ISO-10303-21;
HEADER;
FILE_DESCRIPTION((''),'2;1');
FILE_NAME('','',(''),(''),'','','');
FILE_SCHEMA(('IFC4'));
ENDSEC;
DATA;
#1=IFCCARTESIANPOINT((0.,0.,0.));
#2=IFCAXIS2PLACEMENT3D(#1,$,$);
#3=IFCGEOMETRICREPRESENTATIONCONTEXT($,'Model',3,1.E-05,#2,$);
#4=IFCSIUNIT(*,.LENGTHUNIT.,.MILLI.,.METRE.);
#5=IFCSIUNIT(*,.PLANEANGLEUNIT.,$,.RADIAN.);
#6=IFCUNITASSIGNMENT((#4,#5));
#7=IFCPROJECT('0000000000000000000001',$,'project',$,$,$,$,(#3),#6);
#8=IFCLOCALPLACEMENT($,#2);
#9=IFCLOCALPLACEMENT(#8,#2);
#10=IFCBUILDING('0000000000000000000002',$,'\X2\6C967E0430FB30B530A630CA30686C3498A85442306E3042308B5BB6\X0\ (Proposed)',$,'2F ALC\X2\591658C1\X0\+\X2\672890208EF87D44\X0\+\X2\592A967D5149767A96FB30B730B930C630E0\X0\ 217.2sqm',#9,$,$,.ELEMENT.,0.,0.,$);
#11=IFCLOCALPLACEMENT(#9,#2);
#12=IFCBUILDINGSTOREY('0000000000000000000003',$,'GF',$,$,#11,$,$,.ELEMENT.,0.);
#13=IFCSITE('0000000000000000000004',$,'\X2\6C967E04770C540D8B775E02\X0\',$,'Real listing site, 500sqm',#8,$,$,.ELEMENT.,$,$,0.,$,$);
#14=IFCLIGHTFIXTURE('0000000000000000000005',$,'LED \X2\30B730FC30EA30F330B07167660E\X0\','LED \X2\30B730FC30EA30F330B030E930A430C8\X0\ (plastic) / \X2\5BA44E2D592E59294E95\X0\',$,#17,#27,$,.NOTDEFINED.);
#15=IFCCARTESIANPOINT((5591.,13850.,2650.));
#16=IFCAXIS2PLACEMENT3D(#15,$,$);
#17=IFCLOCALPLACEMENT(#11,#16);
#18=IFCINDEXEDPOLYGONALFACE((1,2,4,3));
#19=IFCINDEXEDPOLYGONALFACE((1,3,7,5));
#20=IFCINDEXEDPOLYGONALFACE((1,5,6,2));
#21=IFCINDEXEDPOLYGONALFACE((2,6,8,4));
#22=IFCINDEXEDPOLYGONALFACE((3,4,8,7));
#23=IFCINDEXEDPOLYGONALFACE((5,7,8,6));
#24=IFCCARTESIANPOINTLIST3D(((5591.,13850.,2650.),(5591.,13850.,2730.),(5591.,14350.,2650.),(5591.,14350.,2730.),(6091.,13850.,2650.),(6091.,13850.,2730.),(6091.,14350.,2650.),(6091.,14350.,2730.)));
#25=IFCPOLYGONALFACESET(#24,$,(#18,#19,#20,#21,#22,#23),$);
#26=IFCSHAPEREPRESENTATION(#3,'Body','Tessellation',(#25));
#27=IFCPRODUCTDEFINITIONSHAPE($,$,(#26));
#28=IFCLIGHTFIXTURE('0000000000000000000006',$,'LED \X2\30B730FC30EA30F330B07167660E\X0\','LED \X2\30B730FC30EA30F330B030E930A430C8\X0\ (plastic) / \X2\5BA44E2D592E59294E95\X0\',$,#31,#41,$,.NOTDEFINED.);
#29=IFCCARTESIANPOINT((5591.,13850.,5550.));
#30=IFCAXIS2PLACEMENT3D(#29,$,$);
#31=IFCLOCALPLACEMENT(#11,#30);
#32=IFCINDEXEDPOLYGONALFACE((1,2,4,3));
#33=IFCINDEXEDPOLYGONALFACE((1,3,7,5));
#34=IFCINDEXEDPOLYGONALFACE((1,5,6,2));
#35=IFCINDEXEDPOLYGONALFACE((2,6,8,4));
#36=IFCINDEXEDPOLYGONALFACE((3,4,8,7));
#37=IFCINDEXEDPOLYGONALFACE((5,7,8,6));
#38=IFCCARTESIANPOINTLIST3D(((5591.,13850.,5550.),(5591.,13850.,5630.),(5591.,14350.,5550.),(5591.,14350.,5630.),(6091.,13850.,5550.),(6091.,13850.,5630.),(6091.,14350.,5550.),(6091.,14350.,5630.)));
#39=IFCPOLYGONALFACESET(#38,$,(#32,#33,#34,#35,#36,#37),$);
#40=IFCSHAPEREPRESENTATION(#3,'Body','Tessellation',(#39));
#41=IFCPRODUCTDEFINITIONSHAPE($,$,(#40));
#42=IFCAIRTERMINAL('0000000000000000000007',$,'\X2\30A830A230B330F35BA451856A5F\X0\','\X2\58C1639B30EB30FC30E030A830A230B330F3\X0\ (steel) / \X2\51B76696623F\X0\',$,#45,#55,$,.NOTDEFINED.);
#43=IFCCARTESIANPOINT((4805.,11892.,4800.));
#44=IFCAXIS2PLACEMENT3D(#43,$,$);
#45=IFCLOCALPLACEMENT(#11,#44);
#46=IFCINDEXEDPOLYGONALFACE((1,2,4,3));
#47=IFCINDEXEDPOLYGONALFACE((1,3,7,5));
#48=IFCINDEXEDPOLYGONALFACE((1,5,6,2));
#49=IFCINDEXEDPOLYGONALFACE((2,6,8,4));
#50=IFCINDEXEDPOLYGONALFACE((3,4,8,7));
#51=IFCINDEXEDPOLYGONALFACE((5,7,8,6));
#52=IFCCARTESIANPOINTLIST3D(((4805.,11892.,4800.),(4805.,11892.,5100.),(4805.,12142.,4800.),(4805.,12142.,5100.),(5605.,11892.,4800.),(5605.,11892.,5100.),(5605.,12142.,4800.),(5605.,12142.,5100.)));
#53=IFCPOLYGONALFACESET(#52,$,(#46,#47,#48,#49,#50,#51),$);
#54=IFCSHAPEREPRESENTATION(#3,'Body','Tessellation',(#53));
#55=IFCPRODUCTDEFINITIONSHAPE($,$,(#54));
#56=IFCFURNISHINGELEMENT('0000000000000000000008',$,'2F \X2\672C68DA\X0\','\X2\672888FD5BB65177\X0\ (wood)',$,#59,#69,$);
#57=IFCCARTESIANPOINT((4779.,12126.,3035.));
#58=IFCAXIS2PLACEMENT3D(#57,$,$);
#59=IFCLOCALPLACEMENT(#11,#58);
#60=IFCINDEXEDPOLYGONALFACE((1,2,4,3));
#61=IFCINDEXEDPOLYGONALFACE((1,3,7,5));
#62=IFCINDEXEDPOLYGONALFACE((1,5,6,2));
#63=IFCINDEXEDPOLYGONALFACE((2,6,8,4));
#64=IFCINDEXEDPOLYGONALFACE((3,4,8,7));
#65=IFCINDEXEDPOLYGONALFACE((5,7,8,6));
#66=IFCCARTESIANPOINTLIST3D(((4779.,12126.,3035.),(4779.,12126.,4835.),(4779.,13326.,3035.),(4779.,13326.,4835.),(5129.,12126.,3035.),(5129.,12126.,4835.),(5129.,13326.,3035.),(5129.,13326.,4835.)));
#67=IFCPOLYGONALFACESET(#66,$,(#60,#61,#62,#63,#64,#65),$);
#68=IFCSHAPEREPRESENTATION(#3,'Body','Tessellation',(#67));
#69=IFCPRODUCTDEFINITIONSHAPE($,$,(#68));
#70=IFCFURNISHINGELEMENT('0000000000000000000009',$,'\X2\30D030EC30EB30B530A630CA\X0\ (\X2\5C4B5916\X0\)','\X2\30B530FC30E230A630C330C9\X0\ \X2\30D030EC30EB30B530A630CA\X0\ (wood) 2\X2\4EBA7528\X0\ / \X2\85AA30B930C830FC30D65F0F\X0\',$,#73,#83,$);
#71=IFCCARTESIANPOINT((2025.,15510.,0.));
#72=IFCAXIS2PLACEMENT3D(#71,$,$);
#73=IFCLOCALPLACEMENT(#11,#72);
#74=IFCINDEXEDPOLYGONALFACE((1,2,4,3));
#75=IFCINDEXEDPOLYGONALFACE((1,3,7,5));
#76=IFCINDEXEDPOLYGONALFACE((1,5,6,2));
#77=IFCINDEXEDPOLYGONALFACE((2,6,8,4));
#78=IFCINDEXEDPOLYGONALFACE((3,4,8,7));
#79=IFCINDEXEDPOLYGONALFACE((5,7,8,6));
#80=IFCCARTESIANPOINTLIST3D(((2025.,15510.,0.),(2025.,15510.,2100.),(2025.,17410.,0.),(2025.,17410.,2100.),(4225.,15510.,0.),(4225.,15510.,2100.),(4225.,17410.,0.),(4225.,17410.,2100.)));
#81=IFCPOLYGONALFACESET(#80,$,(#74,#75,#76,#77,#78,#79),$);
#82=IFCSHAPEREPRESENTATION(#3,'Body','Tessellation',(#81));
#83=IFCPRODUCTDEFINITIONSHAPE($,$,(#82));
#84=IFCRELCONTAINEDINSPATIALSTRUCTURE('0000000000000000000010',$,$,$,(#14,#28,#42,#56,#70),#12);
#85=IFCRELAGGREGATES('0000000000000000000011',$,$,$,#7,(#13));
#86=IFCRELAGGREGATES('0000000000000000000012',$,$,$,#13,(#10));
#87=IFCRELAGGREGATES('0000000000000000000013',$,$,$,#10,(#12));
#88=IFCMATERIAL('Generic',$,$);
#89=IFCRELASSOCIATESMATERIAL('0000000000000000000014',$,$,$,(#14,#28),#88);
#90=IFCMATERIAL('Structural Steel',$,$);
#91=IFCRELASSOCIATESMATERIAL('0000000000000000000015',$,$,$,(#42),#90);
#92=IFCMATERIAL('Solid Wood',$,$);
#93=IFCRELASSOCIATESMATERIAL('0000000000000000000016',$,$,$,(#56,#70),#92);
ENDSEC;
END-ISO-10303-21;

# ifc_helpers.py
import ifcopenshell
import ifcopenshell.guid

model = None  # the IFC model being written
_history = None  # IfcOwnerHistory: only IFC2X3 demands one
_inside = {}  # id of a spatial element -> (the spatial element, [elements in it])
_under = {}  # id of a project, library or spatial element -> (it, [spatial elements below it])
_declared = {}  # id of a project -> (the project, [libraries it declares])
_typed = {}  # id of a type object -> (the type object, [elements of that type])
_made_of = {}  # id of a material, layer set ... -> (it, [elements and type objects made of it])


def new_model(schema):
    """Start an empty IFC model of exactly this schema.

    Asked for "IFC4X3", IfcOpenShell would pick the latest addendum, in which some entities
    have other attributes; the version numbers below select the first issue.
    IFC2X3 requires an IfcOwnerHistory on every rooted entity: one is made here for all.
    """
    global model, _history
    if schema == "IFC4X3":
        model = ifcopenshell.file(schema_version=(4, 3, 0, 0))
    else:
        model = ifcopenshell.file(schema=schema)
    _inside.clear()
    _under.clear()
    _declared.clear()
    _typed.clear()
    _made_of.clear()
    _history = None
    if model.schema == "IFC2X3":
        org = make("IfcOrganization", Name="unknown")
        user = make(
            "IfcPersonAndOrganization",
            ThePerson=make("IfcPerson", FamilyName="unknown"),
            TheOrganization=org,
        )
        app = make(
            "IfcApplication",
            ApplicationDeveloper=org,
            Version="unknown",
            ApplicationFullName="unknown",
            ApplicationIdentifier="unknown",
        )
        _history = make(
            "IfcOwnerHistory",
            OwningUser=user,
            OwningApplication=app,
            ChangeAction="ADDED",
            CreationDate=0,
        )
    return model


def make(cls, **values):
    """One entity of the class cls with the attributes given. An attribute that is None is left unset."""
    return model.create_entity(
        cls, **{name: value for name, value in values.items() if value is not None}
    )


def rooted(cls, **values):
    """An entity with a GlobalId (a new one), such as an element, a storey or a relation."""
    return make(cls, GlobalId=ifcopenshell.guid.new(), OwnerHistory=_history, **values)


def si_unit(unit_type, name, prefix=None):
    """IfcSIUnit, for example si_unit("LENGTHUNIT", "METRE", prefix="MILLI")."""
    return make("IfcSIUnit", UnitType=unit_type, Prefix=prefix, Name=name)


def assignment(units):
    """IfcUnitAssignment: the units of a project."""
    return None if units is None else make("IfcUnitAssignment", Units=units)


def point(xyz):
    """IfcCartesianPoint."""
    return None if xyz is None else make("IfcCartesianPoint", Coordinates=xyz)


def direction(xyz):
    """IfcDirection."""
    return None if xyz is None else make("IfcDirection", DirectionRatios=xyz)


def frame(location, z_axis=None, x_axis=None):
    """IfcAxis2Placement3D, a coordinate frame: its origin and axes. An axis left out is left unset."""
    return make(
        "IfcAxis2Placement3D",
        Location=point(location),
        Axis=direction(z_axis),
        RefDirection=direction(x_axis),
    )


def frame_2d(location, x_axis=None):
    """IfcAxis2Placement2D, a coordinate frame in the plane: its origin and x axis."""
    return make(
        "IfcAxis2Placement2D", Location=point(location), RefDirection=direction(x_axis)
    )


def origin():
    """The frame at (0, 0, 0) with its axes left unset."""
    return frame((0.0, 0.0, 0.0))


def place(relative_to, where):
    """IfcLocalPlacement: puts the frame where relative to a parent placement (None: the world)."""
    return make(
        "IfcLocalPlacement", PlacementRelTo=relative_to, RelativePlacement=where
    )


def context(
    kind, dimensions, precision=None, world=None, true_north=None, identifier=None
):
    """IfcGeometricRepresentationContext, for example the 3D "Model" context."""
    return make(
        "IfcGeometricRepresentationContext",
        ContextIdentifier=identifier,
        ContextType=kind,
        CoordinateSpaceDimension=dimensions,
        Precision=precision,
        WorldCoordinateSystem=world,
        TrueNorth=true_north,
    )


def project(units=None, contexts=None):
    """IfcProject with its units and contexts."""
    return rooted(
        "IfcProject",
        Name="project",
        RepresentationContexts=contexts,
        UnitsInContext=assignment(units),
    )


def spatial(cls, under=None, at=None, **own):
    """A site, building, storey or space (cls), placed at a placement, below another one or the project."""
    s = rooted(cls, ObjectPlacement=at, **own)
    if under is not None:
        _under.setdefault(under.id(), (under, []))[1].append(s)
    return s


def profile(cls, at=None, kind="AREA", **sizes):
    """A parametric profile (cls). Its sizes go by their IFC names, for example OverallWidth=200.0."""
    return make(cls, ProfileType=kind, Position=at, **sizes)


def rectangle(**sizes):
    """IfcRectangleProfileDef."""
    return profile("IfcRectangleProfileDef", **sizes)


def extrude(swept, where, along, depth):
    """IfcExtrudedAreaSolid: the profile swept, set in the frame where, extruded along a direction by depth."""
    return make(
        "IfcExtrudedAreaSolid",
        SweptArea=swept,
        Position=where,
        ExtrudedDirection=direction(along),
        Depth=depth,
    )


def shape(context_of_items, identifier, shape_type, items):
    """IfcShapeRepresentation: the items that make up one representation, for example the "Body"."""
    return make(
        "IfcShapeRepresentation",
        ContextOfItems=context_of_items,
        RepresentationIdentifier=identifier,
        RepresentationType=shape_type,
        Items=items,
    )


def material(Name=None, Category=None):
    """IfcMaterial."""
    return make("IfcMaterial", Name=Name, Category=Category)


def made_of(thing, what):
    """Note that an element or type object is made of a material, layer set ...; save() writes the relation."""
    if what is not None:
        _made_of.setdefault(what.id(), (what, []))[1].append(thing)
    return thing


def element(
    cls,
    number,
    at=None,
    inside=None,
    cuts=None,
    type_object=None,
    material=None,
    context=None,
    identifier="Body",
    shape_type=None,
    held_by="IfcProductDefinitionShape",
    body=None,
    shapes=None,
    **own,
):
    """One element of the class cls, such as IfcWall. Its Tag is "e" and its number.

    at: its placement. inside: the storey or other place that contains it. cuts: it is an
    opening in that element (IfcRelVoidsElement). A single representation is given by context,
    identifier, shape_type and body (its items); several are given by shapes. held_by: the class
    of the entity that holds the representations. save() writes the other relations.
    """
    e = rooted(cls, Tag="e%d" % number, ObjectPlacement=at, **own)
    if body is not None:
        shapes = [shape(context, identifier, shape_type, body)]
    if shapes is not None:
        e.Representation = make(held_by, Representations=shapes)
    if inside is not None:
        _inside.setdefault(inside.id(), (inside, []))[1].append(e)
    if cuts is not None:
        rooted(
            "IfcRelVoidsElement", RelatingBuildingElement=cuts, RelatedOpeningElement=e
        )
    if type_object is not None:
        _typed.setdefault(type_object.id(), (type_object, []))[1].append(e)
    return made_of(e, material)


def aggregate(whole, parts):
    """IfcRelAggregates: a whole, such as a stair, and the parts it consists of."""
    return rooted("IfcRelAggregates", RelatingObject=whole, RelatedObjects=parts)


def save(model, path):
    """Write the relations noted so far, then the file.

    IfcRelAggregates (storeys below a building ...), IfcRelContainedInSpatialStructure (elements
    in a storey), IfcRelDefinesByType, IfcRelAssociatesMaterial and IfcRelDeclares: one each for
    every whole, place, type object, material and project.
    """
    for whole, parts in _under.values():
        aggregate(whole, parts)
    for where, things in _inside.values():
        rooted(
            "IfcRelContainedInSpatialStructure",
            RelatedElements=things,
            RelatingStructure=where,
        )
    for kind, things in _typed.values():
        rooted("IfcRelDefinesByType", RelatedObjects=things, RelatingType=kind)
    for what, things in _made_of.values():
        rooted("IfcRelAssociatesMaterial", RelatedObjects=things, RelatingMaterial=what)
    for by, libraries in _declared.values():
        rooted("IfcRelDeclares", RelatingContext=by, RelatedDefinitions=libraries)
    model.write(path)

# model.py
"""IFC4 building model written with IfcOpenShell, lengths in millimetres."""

from ifc_helpers import new_model, si_unit, frame, frame_2d, origin, place, context, project, spatial, rectangle, extrude, material, element, save


model = new_model("IFC4")

# Units and contexts
model_context = context("Model", 3, precision=1e-05, world=origin())
ifc_project = project(units=[si_unit("LENGTHUNIT", "METRE", prefix="MILLI"), si_unit("PLANEANGLEUNIT", "RADIAN")], contexts=[model_context])

# Site, building, storey
site_placement = place(None, origin())
site = spatial("IfcSite", under=ifc_project, at=site_placement, Name="沖縄県名護市", ObjectType="Real listing site, 500sqm", CompositionType="ELEMENT", RefElevation=0.0)
building_placement = place(site_placement, origin())
building = spatial("IfcBuilding", under=site, at=building_placement, Name="沖縄・サウナと水風呂のある家 (Proposed)", ObjectType="2F ALC外壁+木造軸組+太陽光発電システム 217.2sqm", CompositionType="ELEMENT", ElevationOfRefHeight=0.0, ElevationOfTerrain=0.0)
storey_placement = place(building_placement, origin())
storey = spatial("IfcBuildingStorey", under=building, at=storey_placement, Name="GF", CompositionType="ELEMENT", Elevation=0.0)

# Shared definitions
ifc_material_1 = material(Name="Solid Wood")

# Shared definitions
ifc_material_2 = material(Name="Structural Steel")

# Shared definitions
ifc_material_3 = material(Name="Generic")

# Light fixtures
light_fixture_1_placement = place(storey_placement, frame((5591.0, 13850.0, 2650.0)))
element("IfcLightFixture", 1, at=light_fixture_1_placement, inside=storey, material=ifc_material_3, Name="LED シーリング照明", Description="LED シーリングライト (plastic) / 室中央天井", PredefinedType="NOTDEFINED", context=model_context, shape_type="SweptSolid", body=[
    extrude(rectangle(XDim=500.0, YDim=500.0, at=frame_2d((250.0, 250.0))), frame((5591.0, 13850.0, 2650.0)), (0.0, 0.0, 1.0), 80.0),
])
light_fixture_2_placement = place(storey_placement, frame((5591.0, 13850.0, 5550.0)))
element("IfcLightFixture", 2, at=light_fixture_2_placement, inside=storey, material=ifc_material_3, Name="LED シーリング照明", Description="LED シーリングライト (plastic) / 室中央天井", PredefinedType="NOTDEFINED", context=model_context, shape_type="SweptSolid", body=[
    extrude(rectangle(XDim=500.0, YDim=500.0, at=frame_2d((250.0, 250.0))), frame((5591.0, 13850.0, 5550.0)), (0.0, 0.0, 1.0), 80.0),
])

# Air terminal
air_terminal_placement = place(storey_placement, frame((4805.0, 11892.0, 4800.0)))
element("IfcAirTerminal", 3, at=air_terminal_placement, inside=storey, material=ifc_material_2, Name="エアコン室内機", Description="壁掛ルームエアコン (steel) / 冷暖房", PredefinedType="NOTDEFINED", context=model_context, shape_type="SweptSolid", body=[
    extrude(rectangle(XDim=800.0, YDim=250.0, at=frame_2d((400.0, 125.0))), frame((4805.0, 11892.0, 4800.0)), (0.0, 0.0, 1.0), 300.0),
])

# Furnishing elements
furnishing_1_placement = place(storey_placement, frame((4779.0, 12126.0, 3035.0)))
element("IfcFurnishingElement", 4, at=furnishing_1_placement, inside=storey, material=ifc_material_1, Name="2F 本棚", Description="木製家具 (wood)", context=model_context, shape_type="SweptSolid", body=[
    extrude(rectangle(XDim=350.0, YDim=1200.0, at=frame_2d((175.0, 600.0))), frame((4779.0, 12126.0, 3035.0)), (0.0, 0.0, 1.0), 1800.0),
])
furnishing_2_placement = place(storey_placement, frame((2025.0, 15510.0, 0.0)))
element("IfcFurnishingElement", 5, at=furnishing_2_placement, inside=storey, material=ifc_material_1, Name="バレルサウナ (屋外)", Description="サーモウッド バレルサウナ (wood) 2人用 / 薪ストーブ式", context=model_context, shape_type="SweptSolid", body=[
    extrude(rectangle(XDim=2200.0, YDim=1900.0, at=frame_2d((1100.0, 950.0))), frame((2025.0, 15510.0, 0.0)), (0.0, 0.0, 1.0), 2100.0),
])

save(model, "model.ifc")
